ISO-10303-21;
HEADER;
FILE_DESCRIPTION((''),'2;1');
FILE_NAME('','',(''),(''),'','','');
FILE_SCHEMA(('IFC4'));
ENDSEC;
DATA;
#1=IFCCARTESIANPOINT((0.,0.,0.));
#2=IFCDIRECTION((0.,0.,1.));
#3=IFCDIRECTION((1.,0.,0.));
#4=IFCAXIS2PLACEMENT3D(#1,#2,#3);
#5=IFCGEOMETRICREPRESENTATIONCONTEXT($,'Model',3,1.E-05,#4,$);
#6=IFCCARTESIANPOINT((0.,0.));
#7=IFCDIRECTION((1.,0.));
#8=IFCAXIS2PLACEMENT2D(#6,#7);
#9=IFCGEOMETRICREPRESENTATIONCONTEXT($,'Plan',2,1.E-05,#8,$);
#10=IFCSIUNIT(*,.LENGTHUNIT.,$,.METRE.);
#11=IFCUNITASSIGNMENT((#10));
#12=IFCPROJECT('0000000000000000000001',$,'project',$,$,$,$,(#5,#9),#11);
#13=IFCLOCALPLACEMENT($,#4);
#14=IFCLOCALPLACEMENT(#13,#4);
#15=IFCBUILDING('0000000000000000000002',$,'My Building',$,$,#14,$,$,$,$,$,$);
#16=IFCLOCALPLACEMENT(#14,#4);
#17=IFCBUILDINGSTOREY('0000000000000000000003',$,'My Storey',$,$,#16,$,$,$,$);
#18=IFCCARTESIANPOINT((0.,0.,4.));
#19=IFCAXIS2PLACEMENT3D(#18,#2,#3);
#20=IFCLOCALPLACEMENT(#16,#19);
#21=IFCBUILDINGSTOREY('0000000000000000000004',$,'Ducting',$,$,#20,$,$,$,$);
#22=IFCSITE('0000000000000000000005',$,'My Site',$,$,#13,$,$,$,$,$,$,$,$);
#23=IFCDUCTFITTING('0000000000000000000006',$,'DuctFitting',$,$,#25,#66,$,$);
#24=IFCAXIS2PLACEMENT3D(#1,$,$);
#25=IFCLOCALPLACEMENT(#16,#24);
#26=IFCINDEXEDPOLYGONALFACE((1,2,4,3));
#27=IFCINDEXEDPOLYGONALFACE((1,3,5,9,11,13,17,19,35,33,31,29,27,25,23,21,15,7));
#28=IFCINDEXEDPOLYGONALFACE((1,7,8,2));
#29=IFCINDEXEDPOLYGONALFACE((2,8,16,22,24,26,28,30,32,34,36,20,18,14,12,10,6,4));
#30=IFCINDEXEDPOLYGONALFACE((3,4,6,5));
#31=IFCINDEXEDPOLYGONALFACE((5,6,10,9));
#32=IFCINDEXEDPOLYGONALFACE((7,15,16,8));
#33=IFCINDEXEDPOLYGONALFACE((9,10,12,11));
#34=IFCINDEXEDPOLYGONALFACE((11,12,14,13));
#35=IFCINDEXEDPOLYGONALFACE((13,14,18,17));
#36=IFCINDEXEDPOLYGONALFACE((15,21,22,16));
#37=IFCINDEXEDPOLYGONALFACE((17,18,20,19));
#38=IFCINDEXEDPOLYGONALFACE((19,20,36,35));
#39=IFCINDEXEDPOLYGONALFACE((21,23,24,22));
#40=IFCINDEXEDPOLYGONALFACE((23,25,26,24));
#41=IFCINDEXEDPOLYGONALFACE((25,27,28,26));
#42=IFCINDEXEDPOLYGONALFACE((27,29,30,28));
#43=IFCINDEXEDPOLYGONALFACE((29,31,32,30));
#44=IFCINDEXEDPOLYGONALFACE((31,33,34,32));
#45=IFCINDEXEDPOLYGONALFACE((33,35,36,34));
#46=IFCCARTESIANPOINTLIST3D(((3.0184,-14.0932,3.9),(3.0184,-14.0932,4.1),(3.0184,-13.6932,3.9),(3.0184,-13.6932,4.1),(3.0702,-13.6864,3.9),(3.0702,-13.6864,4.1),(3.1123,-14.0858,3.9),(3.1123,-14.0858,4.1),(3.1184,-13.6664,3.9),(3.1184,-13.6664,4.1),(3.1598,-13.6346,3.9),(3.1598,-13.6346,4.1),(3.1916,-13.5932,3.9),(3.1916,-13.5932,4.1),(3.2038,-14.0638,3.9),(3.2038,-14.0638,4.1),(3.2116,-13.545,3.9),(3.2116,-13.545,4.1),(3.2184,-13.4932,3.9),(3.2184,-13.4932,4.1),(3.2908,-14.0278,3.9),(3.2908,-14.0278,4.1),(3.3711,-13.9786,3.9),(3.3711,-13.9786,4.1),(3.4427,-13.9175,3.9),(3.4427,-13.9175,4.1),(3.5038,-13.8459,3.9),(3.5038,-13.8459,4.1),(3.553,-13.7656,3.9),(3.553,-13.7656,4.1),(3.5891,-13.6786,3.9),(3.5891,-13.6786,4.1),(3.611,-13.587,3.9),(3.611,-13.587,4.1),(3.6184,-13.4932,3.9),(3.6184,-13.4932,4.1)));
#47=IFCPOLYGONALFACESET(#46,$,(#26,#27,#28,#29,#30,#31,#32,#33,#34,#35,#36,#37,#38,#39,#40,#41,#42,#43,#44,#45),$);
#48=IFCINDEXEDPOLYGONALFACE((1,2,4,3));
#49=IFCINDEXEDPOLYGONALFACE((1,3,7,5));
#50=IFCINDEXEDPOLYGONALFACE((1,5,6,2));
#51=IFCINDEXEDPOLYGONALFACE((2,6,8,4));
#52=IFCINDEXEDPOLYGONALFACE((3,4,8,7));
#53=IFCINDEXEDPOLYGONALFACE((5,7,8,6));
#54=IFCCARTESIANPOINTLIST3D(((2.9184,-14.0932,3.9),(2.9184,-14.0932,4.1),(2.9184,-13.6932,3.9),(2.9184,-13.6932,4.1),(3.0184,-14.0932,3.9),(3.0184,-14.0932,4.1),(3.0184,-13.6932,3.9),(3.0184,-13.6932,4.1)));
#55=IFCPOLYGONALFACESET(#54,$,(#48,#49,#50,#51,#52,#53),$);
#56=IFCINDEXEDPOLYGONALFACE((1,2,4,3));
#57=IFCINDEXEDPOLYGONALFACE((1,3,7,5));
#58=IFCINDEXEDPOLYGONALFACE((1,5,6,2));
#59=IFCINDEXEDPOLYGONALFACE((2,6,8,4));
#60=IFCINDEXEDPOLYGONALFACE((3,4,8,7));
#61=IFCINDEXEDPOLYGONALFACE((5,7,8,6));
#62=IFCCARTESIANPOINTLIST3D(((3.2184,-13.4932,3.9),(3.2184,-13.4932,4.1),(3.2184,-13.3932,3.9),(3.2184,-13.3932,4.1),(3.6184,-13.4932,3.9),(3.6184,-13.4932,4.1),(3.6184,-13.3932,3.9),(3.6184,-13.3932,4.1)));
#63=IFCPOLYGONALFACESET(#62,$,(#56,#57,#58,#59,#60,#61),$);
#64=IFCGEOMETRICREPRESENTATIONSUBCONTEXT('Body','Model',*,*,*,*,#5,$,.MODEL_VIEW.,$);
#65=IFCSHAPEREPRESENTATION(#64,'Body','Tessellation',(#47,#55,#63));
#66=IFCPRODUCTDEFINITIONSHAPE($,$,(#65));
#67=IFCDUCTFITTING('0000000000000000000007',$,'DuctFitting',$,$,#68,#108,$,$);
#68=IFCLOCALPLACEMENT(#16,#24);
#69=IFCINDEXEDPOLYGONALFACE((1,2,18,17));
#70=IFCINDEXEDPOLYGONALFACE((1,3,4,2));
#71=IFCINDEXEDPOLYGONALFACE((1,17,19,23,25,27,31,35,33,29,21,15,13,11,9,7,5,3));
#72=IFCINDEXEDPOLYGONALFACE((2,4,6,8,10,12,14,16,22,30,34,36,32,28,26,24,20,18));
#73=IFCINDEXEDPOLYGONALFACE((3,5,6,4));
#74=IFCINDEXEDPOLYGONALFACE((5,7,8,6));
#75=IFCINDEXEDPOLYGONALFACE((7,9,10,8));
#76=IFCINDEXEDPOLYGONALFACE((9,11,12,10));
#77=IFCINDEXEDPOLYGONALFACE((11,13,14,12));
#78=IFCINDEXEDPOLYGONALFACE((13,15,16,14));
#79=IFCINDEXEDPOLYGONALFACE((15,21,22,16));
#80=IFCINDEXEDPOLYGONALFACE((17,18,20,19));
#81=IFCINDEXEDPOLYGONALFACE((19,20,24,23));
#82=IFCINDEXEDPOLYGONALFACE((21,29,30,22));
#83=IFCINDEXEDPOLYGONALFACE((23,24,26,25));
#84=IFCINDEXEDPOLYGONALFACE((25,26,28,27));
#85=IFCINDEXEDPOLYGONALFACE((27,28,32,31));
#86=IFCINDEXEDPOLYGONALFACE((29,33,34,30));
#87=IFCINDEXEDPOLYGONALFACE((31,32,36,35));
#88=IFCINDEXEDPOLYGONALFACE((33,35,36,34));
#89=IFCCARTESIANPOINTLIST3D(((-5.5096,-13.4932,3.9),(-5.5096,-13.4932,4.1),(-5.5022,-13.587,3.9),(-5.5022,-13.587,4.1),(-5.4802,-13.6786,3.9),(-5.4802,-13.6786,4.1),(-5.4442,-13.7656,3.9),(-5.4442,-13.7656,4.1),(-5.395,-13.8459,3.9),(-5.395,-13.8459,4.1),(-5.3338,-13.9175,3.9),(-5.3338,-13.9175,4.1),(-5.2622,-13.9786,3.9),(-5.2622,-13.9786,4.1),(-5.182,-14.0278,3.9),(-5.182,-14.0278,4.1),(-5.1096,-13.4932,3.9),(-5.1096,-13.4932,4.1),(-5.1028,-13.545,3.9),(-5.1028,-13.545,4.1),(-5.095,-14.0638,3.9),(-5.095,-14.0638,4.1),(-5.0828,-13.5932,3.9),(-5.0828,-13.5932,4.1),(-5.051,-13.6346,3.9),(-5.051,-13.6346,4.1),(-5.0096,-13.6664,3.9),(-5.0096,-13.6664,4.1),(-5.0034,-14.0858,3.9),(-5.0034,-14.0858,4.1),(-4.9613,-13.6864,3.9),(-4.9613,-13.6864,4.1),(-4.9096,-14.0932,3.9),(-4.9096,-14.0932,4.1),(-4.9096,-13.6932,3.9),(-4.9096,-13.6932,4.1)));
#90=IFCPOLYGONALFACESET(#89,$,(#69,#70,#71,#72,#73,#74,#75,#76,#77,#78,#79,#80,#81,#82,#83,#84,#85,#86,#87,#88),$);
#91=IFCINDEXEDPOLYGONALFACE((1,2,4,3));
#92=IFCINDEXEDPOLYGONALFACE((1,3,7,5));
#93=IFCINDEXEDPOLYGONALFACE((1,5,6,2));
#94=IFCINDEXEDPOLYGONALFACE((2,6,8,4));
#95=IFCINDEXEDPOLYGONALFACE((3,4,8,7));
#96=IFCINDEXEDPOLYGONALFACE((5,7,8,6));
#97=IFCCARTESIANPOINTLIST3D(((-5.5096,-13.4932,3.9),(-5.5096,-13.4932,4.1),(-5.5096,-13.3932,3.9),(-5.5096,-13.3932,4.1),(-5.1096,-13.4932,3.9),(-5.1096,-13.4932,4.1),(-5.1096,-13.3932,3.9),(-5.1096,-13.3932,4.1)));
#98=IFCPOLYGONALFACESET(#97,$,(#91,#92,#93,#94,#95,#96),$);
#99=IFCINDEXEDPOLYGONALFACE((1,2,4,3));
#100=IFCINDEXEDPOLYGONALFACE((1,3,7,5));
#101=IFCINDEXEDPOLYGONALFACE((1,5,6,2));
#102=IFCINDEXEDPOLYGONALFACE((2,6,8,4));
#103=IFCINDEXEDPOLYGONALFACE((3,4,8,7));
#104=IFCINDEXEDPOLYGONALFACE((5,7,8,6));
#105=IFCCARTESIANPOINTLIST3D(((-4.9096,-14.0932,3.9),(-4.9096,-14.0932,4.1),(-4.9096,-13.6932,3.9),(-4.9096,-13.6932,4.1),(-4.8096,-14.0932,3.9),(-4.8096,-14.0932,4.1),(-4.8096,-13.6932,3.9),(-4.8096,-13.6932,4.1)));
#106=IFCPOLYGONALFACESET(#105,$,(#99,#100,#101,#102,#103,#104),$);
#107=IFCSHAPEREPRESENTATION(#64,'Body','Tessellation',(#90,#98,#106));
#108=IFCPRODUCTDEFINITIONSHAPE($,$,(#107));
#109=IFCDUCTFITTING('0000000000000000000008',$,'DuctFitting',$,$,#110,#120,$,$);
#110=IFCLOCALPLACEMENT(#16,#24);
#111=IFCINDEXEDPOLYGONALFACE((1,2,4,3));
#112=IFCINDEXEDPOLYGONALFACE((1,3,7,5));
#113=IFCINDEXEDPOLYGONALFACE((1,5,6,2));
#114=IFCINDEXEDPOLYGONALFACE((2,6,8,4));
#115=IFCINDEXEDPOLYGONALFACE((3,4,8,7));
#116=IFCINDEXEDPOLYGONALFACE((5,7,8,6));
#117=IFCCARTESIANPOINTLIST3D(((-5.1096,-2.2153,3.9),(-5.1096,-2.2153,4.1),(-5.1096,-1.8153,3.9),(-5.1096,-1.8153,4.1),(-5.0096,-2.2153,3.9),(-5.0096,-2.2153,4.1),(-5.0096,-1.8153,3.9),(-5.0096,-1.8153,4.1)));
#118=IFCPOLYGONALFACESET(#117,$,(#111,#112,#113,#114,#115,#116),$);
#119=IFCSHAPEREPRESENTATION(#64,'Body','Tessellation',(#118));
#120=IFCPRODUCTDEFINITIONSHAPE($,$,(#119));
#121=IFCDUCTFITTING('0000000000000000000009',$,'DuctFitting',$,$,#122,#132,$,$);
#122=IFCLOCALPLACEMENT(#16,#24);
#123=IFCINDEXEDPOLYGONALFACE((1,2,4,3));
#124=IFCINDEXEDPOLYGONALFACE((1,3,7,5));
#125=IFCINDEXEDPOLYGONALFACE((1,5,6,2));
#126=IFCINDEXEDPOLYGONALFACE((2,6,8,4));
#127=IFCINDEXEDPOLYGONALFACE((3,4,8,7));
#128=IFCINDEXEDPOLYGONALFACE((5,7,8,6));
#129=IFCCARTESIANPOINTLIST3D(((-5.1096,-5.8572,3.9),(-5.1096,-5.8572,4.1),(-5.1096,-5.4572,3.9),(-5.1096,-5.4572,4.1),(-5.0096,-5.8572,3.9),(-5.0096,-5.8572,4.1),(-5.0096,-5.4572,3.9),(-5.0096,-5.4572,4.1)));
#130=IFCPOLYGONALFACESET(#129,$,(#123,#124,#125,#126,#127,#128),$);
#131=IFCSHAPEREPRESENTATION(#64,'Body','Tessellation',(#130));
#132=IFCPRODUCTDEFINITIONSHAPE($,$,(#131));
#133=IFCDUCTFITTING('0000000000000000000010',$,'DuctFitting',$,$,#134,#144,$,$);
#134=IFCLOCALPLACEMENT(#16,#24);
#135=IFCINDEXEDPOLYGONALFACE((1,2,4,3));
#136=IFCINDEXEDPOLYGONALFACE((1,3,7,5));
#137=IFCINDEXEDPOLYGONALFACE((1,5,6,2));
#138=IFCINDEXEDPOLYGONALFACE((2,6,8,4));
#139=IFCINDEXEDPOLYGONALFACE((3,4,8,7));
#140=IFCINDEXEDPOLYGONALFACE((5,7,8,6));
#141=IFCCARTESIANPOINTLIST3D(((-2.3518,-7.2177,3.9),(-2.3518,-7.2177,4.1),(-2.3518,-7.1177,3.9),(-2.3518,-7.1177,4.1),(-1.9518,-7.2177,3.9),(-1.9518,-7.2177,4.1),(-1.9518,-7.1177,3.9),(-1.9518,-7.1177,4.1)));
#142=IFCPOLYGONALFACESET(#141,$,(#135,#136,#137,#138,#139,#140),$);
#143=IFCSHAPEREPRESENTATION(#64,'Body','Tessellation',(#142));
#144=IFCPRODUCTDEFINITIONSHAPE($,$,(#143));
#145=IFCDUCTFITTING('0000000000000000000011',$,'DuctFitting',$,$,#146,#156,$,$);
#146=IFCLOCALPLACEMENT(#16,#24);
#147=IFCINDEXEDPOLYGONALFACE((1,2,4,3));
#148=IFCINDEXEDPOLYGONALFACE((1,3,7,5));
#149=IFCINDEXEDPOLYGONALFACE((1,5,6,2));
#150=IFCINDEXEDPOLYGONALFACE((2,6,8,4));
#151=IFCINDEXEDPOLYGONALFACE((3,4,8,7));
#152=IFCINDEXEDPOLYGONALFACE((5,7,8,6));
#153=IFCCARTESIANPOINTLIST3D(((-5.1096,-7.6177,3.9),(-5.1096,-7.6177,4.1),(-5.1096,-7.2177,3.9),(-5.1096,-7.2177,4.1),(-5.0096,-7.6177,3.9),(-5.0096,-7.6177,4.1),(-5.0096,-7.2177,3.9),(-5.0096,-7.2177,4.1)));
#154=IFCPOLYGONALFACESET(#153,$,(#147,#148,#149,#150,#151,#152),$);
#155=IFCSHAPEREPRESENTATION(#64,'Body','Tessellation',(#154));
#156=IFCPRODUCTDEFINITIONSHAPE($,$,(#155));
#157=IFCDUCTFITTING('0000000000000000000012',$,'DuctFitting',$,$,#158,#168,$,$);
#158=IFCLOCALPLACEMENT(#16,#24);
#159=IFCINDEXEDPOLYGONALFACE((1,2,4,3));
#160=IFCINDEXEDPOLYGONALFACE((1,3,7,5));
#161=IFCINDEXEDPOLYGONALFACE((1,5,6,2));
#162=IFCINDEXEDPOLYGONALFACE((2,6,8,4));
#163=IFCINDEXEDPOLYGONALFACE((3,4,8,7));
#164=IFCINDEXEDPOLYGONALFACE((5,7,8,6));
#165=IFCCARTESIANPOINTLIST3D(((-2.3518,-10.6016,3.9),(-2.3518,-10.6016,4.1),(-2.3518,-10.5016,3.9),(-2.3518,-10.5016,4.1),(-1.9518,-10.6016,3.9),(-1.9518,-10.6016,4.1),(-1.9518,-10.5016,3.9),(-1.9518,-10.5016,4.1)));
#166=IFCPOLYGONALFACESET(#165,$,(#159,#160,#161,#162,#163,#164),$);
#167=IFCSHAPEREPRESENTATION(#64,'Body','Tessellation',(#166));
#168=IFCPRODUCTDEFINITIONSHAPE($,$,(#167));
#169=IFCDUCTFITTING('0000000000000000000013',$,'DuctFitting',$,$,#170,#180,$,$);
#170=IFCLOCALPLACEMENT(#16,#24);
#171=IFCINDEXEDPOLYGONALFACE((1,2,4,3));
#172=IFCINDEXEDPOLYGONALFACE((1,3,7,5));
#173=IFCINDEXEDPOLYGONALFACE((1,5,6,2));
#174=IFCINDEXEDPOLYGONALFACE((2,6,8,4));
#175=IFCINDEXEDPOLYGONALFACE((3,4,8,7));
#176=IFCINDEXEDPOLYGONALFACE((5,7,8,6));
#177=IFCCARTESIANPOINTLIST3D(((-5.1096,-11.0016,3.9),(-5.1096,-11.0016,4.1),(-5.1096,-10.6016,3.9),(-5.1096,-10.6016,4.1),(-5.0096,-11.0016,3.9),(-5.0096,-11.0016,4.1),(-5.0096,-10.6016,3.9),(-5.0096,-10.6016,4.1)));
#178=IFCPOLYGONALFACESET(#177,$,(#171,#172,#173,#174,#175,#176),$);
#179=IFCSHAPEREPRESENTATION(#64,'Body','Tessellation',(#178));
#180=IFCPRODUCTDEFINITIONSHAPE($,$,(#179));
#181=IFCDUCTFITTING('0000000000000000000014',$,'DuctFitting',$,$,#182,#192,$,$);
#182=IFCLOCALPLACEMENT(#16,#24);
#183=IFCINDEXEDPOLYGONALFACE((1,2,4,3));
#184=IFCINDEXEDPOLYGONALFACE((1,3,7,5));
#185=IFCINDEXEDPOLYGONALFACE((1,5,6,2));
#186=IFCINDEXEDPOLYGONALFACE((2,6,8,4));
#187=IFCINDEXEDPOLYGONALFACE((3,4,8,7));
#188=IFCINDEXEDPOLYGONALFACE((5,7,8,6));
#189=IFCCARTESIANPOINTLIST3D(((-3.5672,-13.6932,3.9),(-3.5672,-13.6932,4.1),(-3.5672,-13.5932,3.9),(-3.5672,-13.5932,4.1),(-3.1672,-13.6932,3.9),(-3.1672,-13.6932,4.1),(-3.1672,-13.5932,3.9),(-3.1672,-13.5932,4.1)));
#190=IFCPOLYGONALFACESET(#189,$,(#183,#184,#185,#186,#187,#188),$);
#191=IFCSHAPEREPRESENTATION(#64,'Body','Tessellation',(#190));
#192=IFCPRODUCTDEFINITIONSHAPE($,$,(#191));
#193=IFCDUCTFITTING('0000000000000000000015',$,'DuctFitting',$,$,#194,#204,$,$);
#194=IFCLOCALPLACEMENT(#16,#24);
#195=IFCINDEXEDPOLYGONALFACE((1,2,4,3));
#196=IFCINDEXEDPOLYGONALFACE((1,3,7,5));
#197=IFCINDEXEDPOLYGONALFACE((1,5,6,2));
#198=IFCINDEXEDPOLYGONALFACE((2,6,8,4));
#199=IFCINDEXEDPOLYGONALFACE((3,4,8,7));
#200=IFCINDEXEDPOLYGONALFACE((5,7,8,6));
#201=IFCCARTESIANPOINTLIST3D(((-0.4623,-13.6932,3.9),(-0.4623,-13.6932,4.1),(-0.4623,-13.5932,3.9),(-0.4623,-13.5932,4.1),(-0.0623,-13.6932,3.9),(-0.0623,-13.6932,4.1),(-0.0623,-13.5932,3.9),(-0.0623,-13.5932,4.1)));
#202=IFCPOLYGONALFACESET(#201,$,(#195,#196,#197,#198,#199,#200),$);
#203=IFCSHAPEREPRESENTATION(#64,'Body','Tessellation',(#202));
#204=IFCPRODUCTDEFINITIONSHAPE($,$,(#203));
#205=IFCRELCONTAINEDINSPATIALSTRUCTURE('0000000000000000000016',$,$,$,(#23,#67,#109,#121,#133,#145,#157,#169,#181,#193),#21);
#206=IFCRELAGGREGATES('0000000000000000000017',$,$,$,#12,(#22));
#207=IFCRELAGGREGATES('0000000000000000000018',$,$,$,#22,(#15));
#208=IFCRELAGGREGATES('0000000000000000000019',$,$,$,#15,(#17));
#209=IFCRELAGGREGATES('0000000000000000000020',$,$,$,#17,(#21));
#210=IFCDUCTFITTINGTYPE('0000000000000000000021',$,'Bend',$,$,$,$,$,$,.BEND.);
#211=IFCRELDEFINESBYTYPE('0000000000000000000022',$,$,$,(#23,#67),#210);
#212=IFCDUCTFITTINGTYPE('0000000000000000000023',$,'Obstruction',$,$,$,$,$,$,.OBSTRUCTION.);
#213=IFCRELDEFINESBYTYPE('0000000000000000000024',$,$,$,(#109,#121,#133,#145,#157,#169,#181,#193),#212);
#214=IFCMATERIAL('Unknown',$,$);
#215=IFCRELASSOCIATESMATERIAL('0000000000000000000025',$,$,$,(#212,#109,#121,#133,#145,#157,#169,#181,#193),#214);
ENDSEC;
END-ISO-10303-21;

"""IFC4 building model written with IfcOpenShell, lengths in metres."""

from ifc_helpers import new_model, si_unit, frame, origin_with_axes, origin_2d_with_axis, place, context, subcontext, project, spatial, line, arc, indexed_curve, rectangle, outline, extrude, source, transform, mapped, material, material_profile, profile_set, profile_usage, type_object, type_shapes, element, save


model = new_model("IFC4")

# Units and contexts
model_context = context("Model", 3, precision=1e-05, world=origin_with_axes())
plan_context = context("Plan", 2, precision=1e-05, world=origin_2d_with_axis())
body_context = subcontext(model_context, "Body", "Model", "MODEL_VIEW")
ifc_project = project(units=[si_unit("LENGTHUNIT", "METRE")], contexts=[model_context, plan_context])

# Site, building, storeys
site_placement = place(None, origin_with_axes())
site = spatial("IfcSite", under=ifc_project, at=site_placement, Name="My Site")
building_placement = place(site_placement, origin_with_axes())
building = spatial("IfcBuilding", under=site, at=building_placement, Name="My Building")
storey_1_placement = place(building_placement, origin_with_axes())
storey_1 = spatial("IfcBuildingStorey", under=building, at=storey_1_placement, Name="My Storey")
storey_2_placement = place(storey_1_placement, frame((0.0, 0.0, 4.0), z_axis=(0.0, 0.0, 1.0), x_axis=(1.0, 0.0, 0.0)))
storey_2 = spatial("IfcBuildingStorey", under=storey_1, at=storey_2_placement, Name="Ducting")

# Shared definitions
ifc_material = material(Name="Unknown")

# Duct fittings
duct_fitting_type_1 = type_object("IfcDuctFittingType", Name="Bend", PredefinedType="BEND")
shared_shape = source(origin_with_axes(), body_context, "Body", "SweptSolid", [
    extrude(outline(indexed_curve([(-0.2, 0.0), (-0.2586, -0.1414), (-0.4, -0.2), (-0.4, -0.6), (0.0243, -0.4243), (0.2, 0.0)], segments=[arc(1, 2, 3), line(3, 4), arc(4, 5, 6), line(6, 1)])), frame((0.0, -0.1, -0.1), z_axis=(0.0, -1.0, 0.0), x_axis=(1.0, 0.0, 0.0)), (0.0, 0.0, -1.0), 0.2),
    extrude(rectangle(XDim=0.4, YDim=0.2), origin_with_axes(), (0.0, 0.0, -1.0), 0.1),
    extrude(rectangle(XDim=0.4, YDim=0.2), frame((-0.4, 0.0, -0.5), z_axis=(-1.0, 0.0, 0.0), x_axis=(0.0, 0.0, -1.0)), (0.0, 0.0, 1.0), 0.1),
])
type_shapes(duct_fitting_type_1, [shared_shape])
for number, where, z_axis, x_axis, name in (
    (1, (2.9184, -13.8932, 0.0), (-1.0, 0.0, 0.0), (0.0, -1.0, 0.0), "DuctFitting"),
    (2, (-5.3096, -13.3932, 0.0), (0.0, 1.0, 0.0), (-1.0, 0.0, 0.0), "DuctFitting"),
):
    element("IfcDuctFitting", number, at=place(storey_2_placement, frame(where, z_axis=z_axis, x_axis=x_axis)), inside=storey_2, type_object=duct_fitting_type_1, Name=name, context=body_context, shape_type="MappedRepresentation", body=[
        mapped(shared_shape, transform((0.0, 0.0, 0.0), x_axis=(1.0, 0.0, 0.0), y_axis=(0.0, 1.0, 0.0), z_axis=(0.0, 0.0, 1.0), scale=1.0)),
    ])
ifc_material_profile_1 = material_profile(ifc_material, rectangle(XDim=0.4, YDim=0.2))
ifc_profile_set_1 = profile_set([ifc_material_profile_1])
ifc_profile_usage_1 = profile_usage(ifc_profile_set_1, cardinal=5)
duct_fitting_type_2 = type_object("IfcDuctFittingType", Name="Obstruction", PredefinedType="OBSTRUCTION", material=ifc_profile_set_1)
duct_fitting_1_placement = place(storey_2_placement, frame((-5.1096, -2.0153, 0.0), z_axis=(1.0, 0.0, 0.0), x_axis=(0.0, 1.0, 0.0)))
element("IfcDuctFitting", 3, at=duct_fitting_1_placement, inside=storey_2, type_object=duct_fitting_type_2, material=ifc_profile_usage_1, Name="DuctFitting", context=body_context, shape_type="SweptSolid", body=[
    extrude(rectangle(XDim=0.4, YDim=0.2), origin_with_axes(), (0.0, 0.0, 1.0), 0.1),
])
ifc_profile_usage_2 = profile_usage(ifc_profile_set_1, cardinal=5)
duct_fitting_2_placement = place(storey_2_placement, frame((-5.1096, -5.6572, 0.0), z_axis=(1.0, 0.0, 0.0), x_axis=(0.0, 1.0, 0.0)))
element("IfcDuctFitting", 4, at=duct_fitting_2_placement, inside=storey_2, type_object=duct_fitting_type_2, material=ifc_profile_usage_2, Name="DuctFitting", context=body_context, shape_type="SweptSolid", body=[
    extrude(rectangle(XDim=0.4, YDim=0.2), origin_with_axes(), (0.0, 0.0, 1.0), 0.1),
])
ifc_profile_usage_3 = profile_usage(ifc_profile_set_1, cardinal=5)
duct_fitting_3_placement = place(storey_2_placement, frame((-2.1518, -7.2177, 0.0), z_axis=(0.0, 1.0, 0.000001), x_axis=(-1.0, 0.0, 0.0)))
element("IfcDuctFitting", 5, at=duct_fitting_3_placement, inside=storey_2, type_object=duct_fitting_type_2, material=ifc_profile_usage_3, Name="DuctFitting", context=body_context, shape_type="SweptSolid", body=[
    extrude(rectangle(XDim=0.4, YDim=0.2), origin_with_axes(), (0.0, 0.0, 1.0), 0.1),
])
ifc_profile_usage_4 = profile_usage(ifc_profile_set_1, cardinal=5)
duct_fitting_4_placement = place(storey_2_placement, frame((-5.1096, -7.4177, 0.0), z_axis=(1.0, 0.0, 0.0), x_axis=(0.0, 1.0, 0.0)))
element("IfcDuctFitting", 6, at=duct_fitting_4_placement, inside=storey_2, type_object=duct_fitting_type_2, material=ifc_profile_usage_4, Name="DuctFitting", context=body_context, shape_type="SweptSolid", body=[
    extrude(rectangle(XDim=0.4, YDim=0.2), origin_with_axes(), (0.0, 0.0, 1.0), 0.1),
])
ifc_profile_usage_5 = profile_usage(ifc_profile_set_1, cardinal=5)
duct_fitting_5_placement = place(storey_2_placement, frame((-2.1518, -10.6016, 0.0), z_axis=(0.0, 1.0, 0.000001), x_axis=(-1.0, 0.0, 0.0)))
element("IfcDuctFitting", 7, at=duct_fitting_5_placement, inside=storey_2, type_object=duct_fitting_type_2, material=ifc_profile_usage_5, Name="DuctFitting", context=body_context, shape_type="SweptSolid", body=[
    extrude(rectangle(XDim=0.4, YDim=0.2), origin_with_axes(), (0.0, 0.0, 1.0), 0.1),
])
ifc_profile_usage_6 = profile_usage(ifc_profile_set_1, cardinal=5)
duct_fitting_6_placement = place(storey_2_placement, frame((-5.1096, -10.8016, 0.0), z_axis=(1.0, 0.0, 0.0), x_axis=(0.0, 1.0, 0.0)))
element("IfcDuctFitting", 8, at=duct_fitting_6_placement, inside=storey_2, type_object=duct_fitting_type_2, material=ifc_profile_usage_6, Name="DuctFitting", context=body_context, shape_type="SweptSolid", body=[
    extrude(rectangle(XDim=0.4, YDim=0.2), origin_with_axes(), (0.0, 0.0, 1.0), 0.1),
])
ifc_profile_usage_7 = profile_usage(ifc_profile_set_1, cardinal=5)
duct_fitting_7_placement = place(storey_2_placement, frame((-3.3672, -13.6932, 0.0), z_axis=(0.0, 1.0, 0.000001), x_axis=(-1.0, 0.0, 0.0)))
element("IfcDuctFitting", 9, at=duct_fitting_7_placement, inside=storey_2, type_object=duct_fitting_type_2, material=ifc_profile_usage_7, Name="DuctFitting", context=body_context, shape_type="SweptSolid", body=[
    extrude(rectangle(XDim=0.4, YDim=0.2), origin_with_axes(), (0.0, 0.0, 1.0), 0.1),
])
ifc_profile_usage_8 = profile_usage(ifc_profile_set_1, cardinal=5)
duct_fitting_8_placement = place(storey_2_placement, frame((-0.2623, -13.6932, 0.0), z_axis=(0.0, 1.0, 0.000001), x_axis=(-1.0, 0.0, 0.0)))
element("IfcDuctFitting", 10, at=duct_fitting_8_placement, inside=storey_2, type_object=duct_fitting_type_2, material=ifc_profile_usage_8, Name="DuctFitting", context=body_context, shape_type="SweptSolid", body=[
    extrude(rectangle(XDim=0.4, YDim=0.2), origin_with_axes(), (0.0, 0.0, 1.0), 0.1),
])

save(model, "model.ifc")
